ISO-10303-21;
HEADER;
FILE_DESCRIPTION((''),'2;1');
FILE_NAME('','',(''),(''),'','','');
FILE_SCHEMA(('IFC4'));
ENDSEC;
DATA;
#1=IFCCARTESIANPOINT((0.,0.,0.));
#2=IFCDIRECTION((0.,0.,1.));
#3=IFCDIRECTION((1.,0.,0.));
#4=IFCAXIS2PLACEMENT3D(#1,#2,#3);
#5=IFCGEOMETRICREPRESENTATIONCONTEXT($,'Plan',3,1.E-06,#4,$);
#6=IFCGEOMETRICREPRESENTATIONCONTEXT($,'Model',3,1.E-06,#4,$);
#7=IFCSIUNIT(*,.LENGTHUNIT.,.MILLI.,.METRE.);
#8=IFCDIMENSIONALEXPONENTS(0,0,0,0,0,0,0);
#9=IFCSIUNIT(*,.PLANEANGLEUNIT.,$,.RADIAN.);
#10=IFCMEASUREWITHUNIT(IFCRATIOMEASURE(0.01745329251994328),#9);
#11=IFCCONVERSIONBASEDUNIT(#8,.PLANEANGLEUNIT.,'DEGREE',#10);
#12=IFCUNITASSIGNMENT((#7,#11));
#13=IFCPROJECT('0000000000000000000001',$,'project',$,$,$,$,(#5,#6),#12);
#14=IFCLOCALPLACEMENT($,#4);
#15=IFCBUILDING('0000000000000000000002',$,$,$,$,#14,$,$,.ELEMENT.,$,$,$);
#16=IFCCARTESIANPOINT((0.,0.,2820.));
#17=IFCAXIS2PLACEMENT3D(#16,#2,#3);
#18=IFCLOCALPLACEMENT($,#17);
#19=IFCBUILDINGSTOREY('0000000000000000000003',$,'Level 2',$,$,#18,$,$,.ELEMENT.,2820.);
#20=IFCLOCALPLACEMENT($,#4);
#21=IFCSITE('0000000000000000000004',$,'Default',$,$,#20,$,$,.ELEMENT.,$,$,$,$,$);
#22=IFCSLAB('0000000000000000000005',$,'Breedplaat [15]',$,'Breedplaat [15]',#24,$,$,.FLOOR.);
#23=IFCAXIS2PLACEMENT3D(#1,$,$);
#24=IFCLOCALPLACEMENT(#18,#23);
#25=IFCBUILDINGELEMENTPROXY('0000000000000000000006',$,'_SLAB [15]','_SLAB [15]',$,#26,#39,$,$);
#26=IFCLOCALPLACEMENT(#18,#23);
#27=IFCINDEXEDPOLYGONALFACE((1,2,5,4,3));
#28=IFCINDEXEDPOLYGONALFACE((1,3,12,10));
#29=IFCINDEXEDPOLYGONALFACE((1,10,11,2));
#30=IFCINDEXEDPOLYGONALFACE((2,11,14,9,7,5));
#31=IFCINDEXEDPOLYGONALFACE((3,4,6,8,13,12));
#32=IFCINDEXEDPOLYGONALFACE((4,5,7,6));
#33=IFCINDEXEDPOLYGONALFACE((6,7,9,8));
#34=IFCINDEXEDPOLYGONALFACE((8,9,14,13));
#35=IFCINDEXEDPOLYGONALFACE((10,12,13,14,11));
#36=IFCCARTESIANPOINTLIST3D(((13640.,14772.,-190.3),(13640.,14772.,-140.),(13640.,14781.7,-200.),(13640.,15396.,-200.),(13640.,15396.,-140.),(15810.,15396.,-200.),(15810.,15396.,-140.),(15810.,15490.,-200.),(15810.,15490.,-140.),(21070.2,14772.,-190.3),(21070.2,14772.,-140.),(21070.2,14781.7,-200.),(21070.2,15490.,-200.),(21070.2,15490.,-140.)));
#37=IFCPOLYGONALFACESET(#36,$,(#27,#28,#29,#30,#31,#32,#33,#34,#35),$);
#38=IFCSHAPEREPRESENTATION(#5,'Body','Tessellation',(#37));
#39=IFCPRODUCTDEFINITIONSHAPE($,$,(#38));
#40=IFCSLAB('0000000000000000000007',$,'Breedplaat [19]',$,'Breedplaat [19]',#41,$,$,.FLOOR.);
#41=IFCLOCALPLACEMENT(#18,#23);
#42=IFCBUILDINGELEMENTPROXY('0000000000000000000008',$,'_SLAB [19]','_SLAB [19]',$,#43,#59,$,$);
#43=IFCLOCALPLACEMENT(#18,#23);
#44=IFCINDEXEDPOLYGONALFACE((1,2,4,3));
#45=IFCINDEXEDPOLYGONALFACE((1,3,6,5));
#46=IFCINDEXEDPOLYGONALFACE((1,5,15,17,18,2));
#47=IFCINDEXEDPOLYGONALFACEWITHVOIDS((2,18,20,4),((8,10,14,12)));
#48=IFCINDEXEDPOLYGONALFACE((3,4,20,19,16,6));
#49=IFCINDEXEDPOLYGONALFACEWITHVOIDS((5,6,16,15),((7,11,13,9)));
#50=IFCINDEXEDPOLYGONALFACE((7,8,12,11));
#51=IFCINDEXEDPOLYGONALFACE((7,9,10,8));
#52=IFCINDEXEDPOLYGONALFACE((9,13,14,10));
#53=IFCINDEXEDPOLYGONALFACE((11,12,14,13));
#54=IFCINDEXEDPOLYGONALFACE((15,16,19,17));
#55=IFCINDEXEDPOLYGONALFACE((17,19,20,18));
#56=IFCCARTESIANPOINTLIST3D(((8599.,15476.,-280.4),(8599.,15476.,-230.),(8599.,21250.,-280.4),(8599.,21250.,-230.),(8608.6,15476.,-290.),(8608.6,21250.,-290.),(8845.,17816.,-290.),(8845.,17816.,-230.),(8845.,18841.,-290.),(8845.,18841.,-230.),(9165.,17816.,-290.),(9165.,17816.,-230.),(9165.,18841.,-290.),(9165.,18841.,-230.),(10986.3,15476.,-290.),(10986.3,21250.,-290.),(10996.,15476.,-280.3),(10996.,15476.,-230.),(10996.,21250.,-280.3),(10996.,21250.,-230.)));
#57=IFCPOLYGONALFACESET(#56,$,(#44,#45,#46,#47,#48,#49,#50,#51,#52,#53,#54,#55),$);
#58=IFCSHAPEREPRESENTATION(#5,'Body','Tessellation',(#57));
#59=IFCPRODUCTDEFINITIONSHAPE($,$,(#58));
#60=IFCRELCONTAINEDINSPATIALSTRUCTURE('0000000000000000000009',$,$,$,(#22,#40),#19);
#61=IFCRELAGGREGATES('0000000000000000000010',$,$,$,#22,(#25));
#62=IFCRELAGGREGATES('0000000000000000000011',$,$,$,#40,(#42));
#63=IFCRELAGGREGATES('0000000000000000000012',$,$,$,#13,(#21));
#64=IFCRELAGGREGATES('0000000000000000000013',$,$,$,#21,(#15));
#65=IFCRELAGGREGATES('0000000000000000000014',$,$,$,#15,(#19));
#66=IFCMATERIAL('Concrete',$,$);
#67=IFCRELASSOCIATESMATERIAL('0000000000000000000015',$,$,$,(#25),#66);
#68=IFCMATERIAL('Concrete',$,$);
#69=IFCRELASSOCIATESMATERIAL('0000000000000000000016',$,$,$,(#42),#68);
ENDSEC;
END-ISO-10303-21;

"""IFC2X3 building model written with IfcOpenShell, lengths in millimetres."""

from ifc_helpers import new_model, entity, si_unit, converted_unit, frame, origin_with_axes, origin_2d_with_axis, place, context, project, spatial, polyline, rectangle, outline, extrude, material, element, aggregate, save


model = new_model("IFC2X3")

# Units and contexts
plan_context = context("Plan", 3, precision=1e-06, world=origin_with_axes())
model_context = context("Model", 3, precision=1e-06, world=origin_with_axes())
ifc_project = project(units=[si_unit("LENGTHUNIT", "METRE", prefix="MILLI"), converted_unit("PLANEANGLEUNIT", "DEGREE", entity("IfcRatioMeasure", 0.01745329251994328), si_unit("PLANEANGLEUNIT", "RADIAN"), dimensions=[0, 0, 0, 0, 0, 0, 0])], contexts=[plan_context, model_context])

# Site, building, storey
site_placement = place(None, origin_with_axes())
site = spatial("IfcSite", under=ifc_project, at=site_placement, Name="Default", CompositionType="ELEMENT")
building_placement = place(None, origin_with_axes())
building = spatial("IfcBuilding", under=site, at=building_placement, CompositionType="ELEMENT")
storey_placement = place(None, frame((0.0, 0.0, 2820.0), z_axis=(0.0, 0.0, 1.0), x_axis=(1.0, 0.0, 0.0)))
storey = spatial("IfcBuildingStorey", under=building, at=storey_placement, Name="Level 2", CompositionType="ELEMENT", Elevation=2820.0)

# Slab, building element proxy, opening
slab_1_placement = place(None, frame((13640.0, 14772.0, 2620.0), z_axis=(0.0, 0.0, 1.0), x_axis=(1.0, 0.0, 0.0)))
slab_1 = element("IfcSlab", 1, at=slab_1_placement, inside=storey, Name="Breedplaat [15]", ObjectType="Breedplaat [15]", PredefinedType="FLOOR")
ifc_material_1 = material(Name="Concrete")
proxy_1_placement = place(slab_1_placement, origin_with_axes())
proxy_1 = element("IfcBuildingElementProxy", 2, at=proxy_1_placement, material=ifc_material_1, Name="_SLAB [15]", Description="_SLAB [15]", context=plan_context, shape_type="SweptSolid", body=[
    extrude(outline(polyline([(2170.0, 718.0), (2170.0, 624.0), (0.0, 624.0), (0.0, 0.0), (7430.1, 0.0), (7430.1, 718.0), (2170.0, 718.0)])), origin_with_axes(), (0.0, 0.0, 1.0), 60.0),
])
opening_1_placement = place(None, frame((13640.0, 14772.0, 2620.0), z_axis=(0.0, 0.0, 1.0), x_axis=(1.0, 0.0, 0.0)))
element("IfcOpeningElement", 3, at=opening_1_placement, cuts=proxy_1, ObjectType="Opening", context=plan_context, shape_type="SweptSolid", body=[
    extrude(outline(polyline([(-0.1, -0.1), (-0.1, 10.0), (10.0, -0.1), (-0.1, -0.1)])), frame((-1.2, -0.1, -0.1), z_axis=(1.0, 0.0, 0.0), x_axis=(0.0, 1.0, 0.0)), (0.0, 0.0, 1.0), 7432.4),
])
aggregate(slab_1, [proxy_1])

# Slab, building element proxy, openings
slab_2_placement = place(None, frame((10996.0, 15476.0, 2530.0), z_axis=(0.0, 0.0, 1.0), x_axis=(0.0, 1.0, 0.0)))
slab_2 = element("IfcSlab", 4, at=slab_2_placement, inside=storey, Name="Breedplaat [19]", ObjectType="Breedplaat [19]", PredefinedType="FLOOR")
ifc_material_2 = material(Name="Concrete")
proxy_2_placement = place(slab_2_placement, origin_with_axes())
proxy_2 = element("IfcBuildingElementProxy", 5, at=proxy_2_placement, material=ifc_material_2, Name="_SLAB [19]", Description="_SLAB [19]", context=plan_context, shape_type="SweptSolid", body=[
    extrude(outline(polyline([(0.0, 2397.0), (0.0, 0.0), (5774.0, 0.0), (5774.0, 2397.0), (0.0, 2397.0)])), origin_with_axes(), (0.0, 0.0, 1.0), 60.0),
])
opening_2_placement = place(slab_2_placement, frame((3365.0, 1831.0, 0.0), z_axis=(0.0, 0.0, 1.0), x_axis=(0.0, 1.0, 0.0)))
element("IfcOpeningElement", 6, at=opening_2_placement, cuts=proxy_2, ObjectType="Opening", context=plan_context, shape_type="SolidModel", body=[
    extrude(rectangle(XDim=320.0, YDim=1025.0, at=origin_2d_with_axis()), frame((160.0, 512.5, 0.0), z_axis=(0.0, 0.0, 1.0), x_axis=(1.0, 0.0, 0.0)), (0.0, 0.0, 1.0), 60.0),
])
opening_3_placement = place(None, frame((10996.0, 15476.0, 2530.0), z_axis=(0.0, 0.0, 1.0), x_axis=(0.0, 1.0, 0.0)))
element("IfcOpeningElement", 7, at=opening_3_placement, cuts=proxy_2, ObjectType="Opening", context=plan_context, shape_type="SweptSolid", body=[
    extrude(outline(polyline([(-0.1, -0.1), (-0.1, 10.0), (10.0, -0.1), (-0.1, -0.1)])), frame((-1.2, -0.1, -0.1), z_axis=(1.0, 0.0, 0.0), x_axis=(0.0, 1.0, 0.0)), (0.0, 0.0, 1.0), 5776.2),
])
opening_4_placement = place(None, frame((10996.0, 15476.0, 2530.0), z_axis=(0.0, 0.0, 1.0), x_axis=(0.0, 1.0, 0.0)))
element("IfcOpeningElement", 8, at=opening_4_placement, cuts=proxy_2, ObjectType="Opening", context=plan_context, shape_type="SweptSolid", body=[
    extrude(outline(polyline([(-0.1, -0.1), (-0.1, 10.0), (10.0, -0.1), (-0.1, -0.1)])), frame((5775.2, 2397.2, -0.1), z_axis=(-1.0, 0.0, 0.0), x_axis=(0.0, -1.0, 0.0)), (0.0, 0.0, 1.0), 5776.2),
])
aggregate(slab_2, [proxy_2])

save(model, "model.ifc")
